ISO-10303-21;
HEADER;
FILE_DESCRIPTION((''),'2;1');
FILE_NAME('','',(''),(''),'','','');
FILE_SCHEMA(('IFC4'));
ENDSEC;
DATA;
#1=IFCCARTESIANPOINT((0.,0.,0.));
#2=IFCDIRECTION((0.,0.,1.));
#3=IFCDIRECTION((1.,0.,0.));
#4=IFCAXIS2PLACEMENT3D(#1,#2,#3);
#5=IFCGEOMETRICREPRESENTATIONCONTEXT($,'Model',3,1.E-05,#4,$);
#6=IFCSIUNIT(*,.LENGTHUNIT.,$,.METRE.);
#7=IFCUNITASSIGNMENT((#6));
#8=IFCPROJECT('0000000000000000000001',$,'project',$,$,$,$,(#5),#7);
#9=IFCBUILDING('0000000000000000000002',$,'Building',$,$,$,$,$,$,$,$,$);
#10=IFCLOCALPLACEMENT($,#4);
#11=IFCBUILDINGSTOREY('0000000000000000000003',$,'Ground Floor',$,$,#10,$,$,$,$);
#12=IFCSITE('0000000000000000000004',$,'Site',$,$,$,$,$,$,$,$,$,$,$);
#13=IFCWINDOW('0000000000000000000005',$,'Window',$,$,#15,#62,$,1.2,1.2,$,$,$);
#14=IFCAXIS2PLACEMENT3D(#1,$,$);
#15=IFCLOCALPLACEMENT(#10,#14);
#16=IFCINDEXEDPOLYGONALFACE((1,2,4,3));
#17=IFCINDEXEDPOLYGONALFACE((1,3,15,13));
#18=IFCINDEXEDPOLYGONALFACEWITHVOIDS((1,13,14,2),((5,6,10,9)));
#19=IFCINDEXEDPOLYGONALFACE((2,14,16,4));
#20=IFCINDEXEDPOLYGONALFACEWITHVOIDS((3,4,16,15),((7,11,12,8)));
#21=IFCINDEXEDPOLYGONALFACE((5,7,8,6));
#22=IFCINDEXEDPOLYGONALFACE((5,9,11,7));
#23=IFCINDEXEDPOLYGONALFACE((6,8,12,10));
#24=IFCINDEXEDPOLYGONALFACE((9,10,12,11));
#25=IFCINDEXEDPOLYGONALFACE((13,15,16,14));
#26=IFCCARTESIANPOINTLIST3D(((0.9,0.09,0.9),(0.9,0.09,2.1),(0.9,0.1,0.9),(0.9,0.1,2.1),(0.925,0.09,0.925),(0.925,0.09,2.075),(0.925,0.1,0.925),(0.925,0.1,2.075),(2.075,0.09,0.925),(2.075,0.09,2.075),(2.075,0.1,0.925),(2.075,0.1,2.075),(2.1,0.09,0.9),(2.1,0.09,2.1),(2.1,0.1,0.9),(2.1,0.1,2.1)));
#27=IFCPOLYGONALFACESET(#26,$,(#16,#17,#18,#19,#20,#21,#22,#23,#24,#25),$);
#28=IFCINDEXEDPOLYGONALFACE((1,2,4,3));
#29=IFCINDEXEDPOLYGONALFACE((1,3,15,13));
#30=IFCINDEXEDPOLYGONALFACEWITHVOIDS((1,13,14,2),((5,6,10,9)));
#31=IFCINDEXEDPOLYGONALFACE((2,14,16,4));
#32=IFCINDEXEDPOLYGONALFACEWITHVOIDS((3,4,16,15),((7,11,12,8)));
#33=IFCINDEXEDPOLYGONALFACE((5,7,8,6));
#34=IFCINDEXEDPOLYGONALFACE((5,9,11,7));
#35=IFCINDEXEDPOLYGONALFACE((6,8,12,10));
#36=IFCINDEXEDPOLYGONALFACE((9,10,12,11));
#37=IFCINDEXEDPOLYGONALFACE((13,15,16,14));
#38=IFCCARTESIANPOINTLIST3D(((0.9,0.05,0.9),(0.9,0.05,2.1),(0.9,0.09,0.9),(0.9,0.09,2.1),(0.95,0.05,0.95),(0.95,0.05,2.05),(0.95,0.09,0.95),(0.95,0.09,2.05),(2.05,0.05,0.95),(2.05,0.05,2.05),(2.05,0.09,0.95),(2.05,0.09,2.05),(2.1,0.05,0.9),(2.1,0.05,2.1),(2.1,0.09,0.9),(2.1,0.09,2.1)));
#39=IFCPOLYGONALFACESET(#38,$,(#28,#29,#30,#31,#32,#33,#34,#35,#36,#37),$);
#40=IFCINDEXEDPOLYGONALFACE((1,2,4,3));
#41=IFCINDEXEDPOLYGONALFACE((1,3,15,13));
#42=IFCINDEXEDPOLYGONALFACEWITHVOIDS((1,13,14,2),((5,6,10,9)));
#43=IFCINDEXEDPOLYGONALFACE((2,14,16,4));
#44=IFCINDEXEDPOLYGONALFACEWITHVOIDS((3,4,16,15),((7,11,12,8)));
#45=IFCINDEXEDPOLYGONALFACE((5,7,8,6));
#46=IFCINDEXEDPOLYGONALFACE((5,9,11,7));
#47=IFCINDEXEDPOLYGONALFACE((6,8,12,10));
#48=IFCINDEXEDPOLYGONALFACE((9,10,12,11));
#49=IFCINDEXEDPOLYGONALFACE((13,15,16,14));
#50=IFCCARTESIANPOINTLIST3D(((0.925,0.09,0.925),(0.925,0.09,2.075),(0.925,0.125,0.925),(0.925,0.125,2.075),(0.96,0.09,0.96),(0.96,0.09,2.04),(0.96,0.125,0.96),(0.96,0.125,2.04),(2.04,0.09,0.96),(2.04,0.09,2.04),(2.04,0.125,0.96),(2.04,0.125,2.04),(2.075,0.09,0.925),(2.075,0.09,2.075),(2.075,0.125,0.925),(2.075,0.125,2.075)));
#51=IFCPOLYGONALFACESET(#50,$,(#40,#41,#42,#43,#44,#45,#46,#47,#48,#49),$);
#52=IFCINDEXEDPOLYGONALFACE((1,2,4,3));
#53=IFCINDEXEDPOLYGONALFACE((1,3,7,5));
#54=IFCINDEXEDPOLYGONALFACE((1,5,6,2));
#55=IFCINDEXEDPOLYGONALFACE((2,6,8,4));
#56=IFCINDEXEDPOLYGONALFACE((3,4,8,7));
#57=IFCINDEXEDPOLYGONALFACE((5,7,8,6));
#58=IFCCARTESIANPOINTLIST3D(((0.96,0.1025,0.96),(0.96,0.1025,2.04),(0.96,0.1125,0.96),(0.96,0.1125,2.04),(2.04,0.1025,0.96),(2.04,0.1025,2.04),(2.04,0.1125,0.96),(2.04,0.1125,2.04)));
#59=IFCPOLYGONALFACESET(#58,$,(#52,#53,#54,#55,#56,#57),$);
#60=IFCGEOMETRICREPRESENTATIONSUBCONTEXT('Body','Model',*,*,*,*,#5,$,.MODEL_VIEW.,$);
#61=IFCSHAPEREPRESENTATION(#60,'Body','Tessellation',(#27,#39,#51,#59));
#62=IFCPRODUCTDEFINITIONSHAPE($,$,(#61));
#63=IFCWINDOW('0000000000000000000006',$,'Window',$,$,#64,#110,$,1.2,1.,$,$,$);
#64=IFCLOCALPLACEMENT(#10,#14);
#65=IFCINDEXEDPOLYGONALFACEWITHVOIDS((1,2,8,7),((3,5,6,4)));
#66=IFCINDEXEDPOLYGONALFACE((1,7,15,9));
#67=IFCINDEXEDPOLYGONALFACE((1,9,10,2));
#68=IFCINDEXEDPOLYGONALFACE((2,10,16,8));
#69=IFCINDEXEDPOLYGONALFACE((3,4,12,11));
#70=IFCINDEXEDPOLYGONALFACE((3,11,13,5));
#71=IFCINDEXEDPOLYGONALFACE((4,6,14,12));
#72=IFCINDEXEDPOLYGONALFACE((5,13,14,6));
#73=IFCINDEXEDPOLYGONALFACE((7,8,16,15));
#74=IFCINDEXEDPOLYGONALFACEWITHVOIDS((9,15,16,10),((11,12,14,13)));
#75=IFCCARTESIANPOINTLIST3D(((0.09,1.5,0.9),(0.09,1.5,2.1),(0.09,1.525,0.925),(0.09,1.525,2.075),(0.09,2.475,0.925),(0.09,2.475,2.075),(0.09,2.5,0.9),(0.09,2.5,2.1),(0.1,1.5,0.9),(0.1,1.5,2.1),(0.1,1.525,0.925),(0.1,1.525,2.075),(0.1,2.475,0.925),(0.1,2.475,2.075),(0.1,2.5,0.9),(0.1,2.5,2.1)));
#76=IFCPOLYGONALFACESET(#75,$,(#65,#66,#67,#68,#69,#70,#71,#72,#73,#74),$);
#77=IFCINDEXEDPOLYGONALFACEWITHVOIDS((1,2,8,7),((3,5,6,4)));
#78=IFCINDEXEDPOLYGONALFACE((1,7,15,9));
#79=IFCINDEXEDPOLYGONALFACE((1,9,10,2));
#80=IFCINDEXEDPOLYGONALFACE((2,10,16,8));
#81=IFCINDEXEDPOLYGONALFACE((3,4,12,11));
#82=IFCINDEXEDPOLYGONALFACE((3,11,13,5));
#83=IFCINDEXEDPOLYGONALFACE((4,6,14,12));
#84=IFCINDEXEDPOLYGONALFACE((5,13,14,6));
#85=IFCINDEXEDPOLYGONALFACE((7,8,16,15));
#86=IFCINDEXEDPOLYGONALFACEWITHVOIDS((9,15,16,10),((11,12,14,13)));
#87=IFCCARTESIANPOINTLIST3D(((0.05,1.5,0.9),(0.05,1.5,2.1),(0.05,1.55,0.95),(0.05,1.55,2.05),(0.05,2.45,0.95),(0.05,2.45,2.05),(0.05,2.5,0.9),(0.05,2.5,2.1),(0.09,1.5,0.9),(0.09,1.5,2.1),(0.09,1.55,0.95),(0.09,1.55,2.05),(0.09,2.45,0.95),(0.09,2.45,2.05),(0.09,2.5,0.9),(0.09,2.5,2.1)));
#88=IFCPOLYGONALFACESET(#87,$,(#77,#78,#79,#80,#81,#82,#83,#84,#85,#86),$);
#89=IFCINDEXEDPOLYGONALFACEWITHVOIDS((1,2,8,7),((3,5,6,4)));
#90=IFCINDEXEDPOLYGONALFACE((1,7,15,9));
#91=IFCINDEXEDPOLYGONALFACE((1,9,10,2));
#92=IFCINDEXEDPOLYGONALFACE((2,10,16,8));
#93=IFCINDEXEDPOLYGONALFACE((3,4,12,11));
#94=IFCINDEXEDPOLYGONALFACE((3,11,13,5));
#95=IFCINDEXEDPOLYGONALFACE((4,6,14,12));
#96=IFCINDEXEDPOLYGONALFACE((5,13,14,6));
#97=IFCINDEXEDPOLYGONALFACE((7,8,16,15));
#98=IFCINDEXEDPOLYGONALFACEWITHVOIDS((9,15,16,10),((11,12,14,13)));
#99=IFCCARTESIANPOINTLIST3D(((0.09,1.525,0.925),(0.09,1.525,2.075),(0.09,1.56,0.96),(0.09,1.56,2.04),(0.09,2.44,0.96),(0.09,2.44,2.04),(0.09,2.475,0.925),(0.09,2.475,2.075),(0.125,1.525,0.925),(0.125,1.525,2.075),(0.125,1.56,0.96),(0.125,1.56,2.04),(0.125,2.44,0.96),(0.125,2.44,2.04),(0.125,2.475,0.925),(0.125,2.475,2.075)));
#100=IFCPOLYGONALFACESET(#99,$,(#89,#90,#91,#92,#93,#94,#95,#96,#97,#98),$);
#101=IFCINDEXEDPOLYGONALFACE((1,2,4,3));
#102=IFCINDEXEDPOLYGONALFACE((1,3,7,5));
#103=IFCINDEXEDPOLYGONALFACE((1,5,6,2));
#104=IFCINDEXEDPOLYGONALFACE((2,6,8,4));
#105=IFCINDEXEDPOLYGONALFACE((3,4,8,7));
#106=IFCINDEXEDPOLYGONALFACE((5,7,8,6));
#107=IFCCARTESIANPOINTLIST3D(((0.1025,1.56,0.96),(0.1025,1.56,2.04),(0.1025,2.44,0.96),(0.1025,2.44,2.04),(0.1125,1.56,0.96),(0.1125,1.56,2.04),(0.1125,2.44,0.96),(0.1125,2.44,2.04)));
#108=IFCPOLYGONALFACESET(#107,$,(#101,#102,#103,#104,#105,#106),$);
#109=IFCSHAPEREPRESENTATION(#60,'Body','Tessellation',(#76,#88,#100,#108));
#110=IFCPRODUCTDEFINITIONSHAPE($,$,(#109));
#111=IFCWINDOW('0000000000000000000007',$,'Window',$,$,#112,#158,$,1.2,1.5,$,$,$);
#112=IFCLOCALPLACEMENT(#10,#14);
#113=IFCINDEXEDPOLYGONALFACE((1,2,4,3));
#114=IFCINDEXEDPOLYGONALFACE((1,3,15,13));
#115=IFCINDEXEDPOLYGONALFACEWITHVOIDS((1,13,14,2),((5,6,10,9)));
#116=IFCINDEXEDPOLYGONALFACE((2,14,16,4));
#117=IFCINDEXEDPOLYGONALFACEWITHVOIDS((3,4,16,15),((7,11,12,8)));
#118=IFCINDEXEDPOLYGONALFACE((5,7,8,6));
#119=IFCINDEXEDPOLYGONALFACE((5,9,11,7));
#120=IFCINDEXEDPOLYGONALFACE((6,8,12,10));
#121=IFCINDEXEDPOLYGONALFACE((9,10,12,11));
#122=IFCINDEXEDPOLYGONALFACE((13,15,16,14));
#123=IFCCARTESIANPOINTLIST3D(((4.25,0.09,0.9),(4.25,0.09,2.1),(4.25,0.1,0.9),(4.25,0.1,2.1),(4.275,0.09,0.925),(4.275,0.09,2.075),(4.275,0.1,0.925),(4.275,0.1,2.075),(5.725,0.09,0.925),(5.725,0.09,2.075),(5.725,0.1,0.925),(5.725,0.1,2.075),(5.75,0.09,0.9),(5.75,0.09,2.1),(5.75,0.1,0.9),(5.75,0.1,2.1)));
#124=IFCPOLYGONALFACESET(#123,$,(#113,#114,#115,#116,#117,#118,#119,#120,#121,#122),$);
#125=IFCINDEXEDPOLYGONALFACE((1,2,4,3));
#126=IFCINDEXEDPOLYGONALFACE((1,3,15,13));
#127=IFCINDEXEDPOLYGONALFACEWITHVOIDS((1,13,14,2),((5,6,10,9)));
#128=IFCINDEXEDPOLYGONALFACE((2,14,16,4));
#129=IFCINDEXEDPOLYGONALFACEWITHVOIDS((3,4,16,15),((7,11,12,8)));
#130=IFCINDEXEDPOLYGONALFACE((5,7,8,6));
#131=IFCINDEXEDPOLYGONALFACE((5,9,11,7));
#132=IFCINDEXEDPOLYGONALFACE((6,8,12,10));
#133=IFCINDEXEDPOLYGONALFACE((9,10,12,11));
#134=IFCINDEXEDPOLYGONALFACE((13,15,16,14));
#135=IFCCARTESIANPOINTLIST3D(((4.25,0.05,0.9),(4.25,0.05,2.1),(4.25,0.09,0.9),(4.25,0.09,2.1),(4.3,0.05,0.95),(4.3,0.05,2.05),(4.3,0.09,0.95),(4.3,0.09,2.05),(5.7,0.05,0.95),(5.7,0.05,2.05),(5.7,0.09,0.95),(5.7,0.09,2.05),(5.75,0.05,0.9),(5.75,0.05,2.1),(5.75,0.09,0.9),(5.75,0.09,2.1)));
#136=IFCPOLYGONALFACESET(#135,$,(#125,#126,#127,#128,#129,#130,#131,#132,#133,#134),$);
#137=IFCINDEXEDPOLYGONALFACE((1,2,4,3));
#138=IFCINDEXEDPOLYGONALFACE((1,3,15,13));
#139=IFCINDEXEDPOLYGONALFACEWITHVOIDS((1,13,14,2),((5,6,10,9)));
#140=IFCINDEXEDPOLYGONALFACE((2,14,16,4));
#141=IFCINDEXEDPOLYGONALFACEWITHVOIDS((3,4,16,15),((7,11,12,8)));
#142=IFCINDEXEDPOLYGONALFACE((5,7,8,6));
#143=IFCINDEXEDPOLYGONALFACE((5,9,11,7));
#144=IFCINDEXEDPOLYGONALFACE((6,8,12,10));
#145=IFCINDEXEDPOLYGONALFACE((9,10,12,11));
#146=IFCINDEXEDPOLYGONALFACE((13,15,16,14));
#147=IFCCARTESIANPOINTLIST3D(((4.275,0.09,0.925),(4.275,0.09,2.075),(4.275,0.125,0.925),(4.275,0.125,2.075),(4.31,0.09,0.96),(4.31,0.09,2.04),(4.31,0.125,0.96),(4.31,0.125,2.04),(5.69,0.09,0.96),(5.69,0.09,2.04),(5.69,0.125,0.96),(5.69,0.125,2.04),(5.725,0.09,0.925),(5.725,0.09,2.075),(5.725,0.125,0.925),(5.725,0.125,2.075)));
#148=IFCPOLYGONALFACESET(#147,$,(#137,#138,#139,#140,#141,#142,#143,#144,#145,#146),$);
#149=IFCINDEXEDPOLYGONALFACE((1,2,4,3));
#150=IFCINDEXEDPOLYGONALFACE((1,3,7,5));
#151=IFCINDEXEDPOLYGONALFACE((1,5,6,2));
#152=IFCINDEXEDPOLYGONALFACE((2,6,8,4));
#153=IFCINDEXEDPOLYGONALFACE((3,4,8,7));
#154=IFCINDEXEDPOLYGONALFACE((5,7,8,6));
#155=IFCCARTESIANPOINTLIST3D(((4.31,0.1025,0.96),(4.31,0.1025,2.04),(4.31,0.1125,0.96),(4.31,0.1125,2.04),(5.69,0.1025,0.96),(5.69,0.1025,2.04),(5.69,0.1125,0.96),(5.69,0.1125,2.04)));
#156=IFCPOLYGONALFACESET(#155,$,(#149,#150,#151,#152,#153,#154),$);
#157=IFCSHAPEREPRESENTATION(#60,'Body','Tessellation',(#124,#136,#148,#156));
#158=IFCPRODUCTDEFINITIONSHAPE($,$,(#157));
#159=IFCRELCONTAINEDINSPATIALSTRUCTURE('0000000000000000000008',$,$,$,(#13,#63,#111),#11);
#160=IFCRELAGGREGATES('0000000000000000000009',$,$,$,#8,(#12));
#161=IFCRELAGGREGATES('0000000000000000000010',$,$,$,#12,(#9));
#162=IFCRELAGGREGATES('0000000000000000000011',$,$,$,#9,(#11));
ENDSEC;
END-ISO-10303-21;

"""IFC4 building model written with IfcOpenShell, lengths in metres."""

from ifc_helpers import new_model, si_unit, frame, origin_with_axes, place, context, subcontext, project, spatial, line, indexed_curve, outline, extrude, element, save


model = new_model("IFC4")

# Units and contexts
model_context = context("Model", 3, precision=1e-05, world=origin_with_axes())
body_context = subcontext(model_context, "Body", "Model", "MODEL_VIEW")
ifc_project = project(units=[si_unit("LENGTHUNIT", "METRE")], contexts=[model_context])

# Site, building, storey
site = spatial("IfcSite", under=ifc_project, Name="Site")
building = spatial("IfcBuilding", under=site, Name="Building")
storey_placement = place(None, origin_with_axes())
storey = spatial("IfcBuildingStorey", under=building, at=storey_placement, Name="Ground Floor")

# Windows
window_1_placement = place(storey_placement, frame((0.9, 0.0, 0.9), z_axis=(0.0, 0.0, 1.0), x_axis=(1.0, 0.0, 0.0)))
element("IfcWindow", 1, at=window_1_placement, inside=storey, Name="Window", OverallHeight=1.2, OverallWidth=1.2, context=body_context, shape_type="SweptSolid", body=[
    extrude(outline(indexed_curve([(0.0, 0.0), (1.2, 0.0), (1.2, 1.2), (0.0, 1.2)], segments=[line(1, 2, 3, 4, 1)]), holes=[indexed_curve([(0.025, 0.025), (1.175, 0.025), (1.175, 1.175), (0.025, 1.175)], segments=[line(1, 2, 3, 4, 1)])]), frame((0.0, 0.09, 0.0), z_axis=(0.0, -1.0, 0.0), x_axis=(1.0, 0.0, 0.0)), (0.0, 0.0, -1.0), 0.01),
    extrude(outline(indexed_curve([(0.0, 0.0), (1.2, 0.0), (1.2, 1.2), (0.0, 1.2)], segments=[line(1, 2, 3, 4, 1)]), holes=[indexed_curve([(0.05, 0.05), (1.15, 0.05), (1.15, 1.15), (0.05, 1.15)], segments=[line(1, 2, 3, 4, 1)])]), frame((0.0, 0.05, 0.0), z_axis=(0.0, -1.0, 0.0), x_axis=(1.0, 0.0, 0.0)), (0.0, 0.0, -1.0), 0.04),
    extrude(outline(indexed_curve([(0.0, 0.0), (1.15, 0.0), (1.15, 1.15), (0.0, 1.15)], segments=[line(1, 2, 3, 4, 1)]), holes=[indexed_curve([(0.035, 0.035), (1.115, 0.035), (1.115, 1.115), (0.035, 1.115)], segments=[line(1, 2, 3, 4, 1)])]), frame((0.025, 0.09, 0.025), z_axis=(0.0, -1.0, 0.0), x_axis=(1.0, 0.0, 0.0)), (0.0, 0.0, -1.0), 0.035),
    extrude(outline(indexed_curve([(0.035, 0.035), (1.115, 0.035), (1.115, 1.115), (0.035, 1.115)], segments=[line(1, 2, 3, 4, 1)])), frame((0.025, 0.1025, 0.025), z_axis=(0.0, -1.0, 0.0), x_axis=(1.0, 0.0, 0.0)), (0.0, 0.0, -1.0), 0.01),
])
window_2_placement = place(storey_placement, frame((0.0, 2.5, 0.9), z_axis=(0.0, 0.0, 1.0), x_axis=(0.0, -1.0, 0.0)))
element("IfcWindow", 2, at=window_2_placement, inside=storey, Name="Window", OverallHeight=1.2, OverallWidth=1.0, context=body_context, shape_type="SweptSolid", body=[
    extrude(outline(indexed_curve([(0.0, 0.0), (1.0, 0.0), (1.0, 1.2), (0.0, 1.2)], segments=[line(1, 2, 3, 4, 1)]), holes=[indexed_curve([(0.025, 0.025), (0.975, 0.025), (0.975, 1.175), (0.025, 1.175)], segments=[line(1, 2, 3, 4, 1)])]), frame((0.0, 0.09, 0.0), z_axis=(0.0, -1.0, 0.0), x_axis=(1.0, 0.0, 0.0)), (0.0, 0.0, -1.0), 0.01),
    extrude(outline(indexed_curve([(0.0, 0.0), (1.0, 0.0), (1.0, 1.2), (0.0, 1.2)], segments=[line(1, 2, 3, 4, 1)]), holes=[indexed_curve([(0.05, 0.05), (0.95, 0.05), (0.95, 1.15), (0.05, 1.15)], segments=[line(1, 2, 3, 4, 1)])]), frame((0.0, 0.05, 0.0), z_axis=(0.0, -1.0, 0.0), x_axis=(1.0, 0.0, 0.0)), (0.0, 0.0, -1.0), 0.04),
    extrude(outline(indexed_curve([(0.0, 0.0), (0.95, 0.0), (0.95, 1.15), (0.0, 1.15)], segments=[line(1, 2, 3, 4, 1)]), holes=[indexed_curve([(0.035, 0.035), (0.915, 0.035), (0.915, 1.115), (0.035, 1.115)], segments=[line(1, 2, 3, 4, 1)])]), frame((0.025, 0.09, 0.025), z_axis=(0.0, -1.0, 0.0), x_axis=(1.0, 0.0, 0.0)), (0.0, 0.0, -1.0), 0.035),
    extrude(outline(indexed_curve([(0.035, 0.035), (0.915, 0.035), (0.915, 1.115), (0.035, 1.115)], segments=[line(1, 2, 3, 4, 1)])), frame((0.025, 0.1025, 0.025), z_axis=(0.0, -1.0, 0.0), x_axis=(1.0, 0.0, 0.0)), (0.0, 0.0, -1.0), 0.01),
])
window_3_placement = place(storey_placement, frame((4.25, 0.0, 0.9), z_axis=(0.0, 0.0, 1.0), x_axis=(1.0, 0.0, 0.0)))
element("IfcWindow", 3, at=window_3_placement, inside=storey, Name="Window", OverallHeight=1.2, OverallWidth=1.5, context=body_context, shape_type="SweptSolid", body=[
    extrude(outline(indexed_curve([(0.0, 0.0), (1.5, 0.0), (1.5, 1.2), (0.0, 1.2)], segments=[line(1, 2, 3, 4, 1)]), holes=[indexed_curve([(0.025, 0.025), (1.475, 0.025), (1.475, 1.175), (0.025, 1.175)], segments=[line(1, 2, 3, 4, 1)])]), frame((0.0, 0.09, 0.0), z_axis=(0.0, -1.0, 0.0), x_axis=(1.0, 0.0, 0.0)), (0.0, 0.0, -1.0), 0.01),
    extrude(outline(indexed_curve([(0.0, 0.0), (1.5, 0.0), (1.5, 1.2), (0.0, 1.2)], segments=[line(1, 2, 3, 4, 1)]), holes=[indexed_curve([(0.05, 0.05), (1.45, 0.05), (1.45, 1.15), (0.05, 1.15)], segments=[line(1, 2, 3, 4, 1)])]), frame((0.0, 0.05, 0.0), z_axis=(0.0, -1.0, 0.0), x_axis=(1.0, 0.0, 0.0)), (0.0, 0.0, -1.0), 0.04),
    extrude(outline(indexed_curve([(0.0, 0.0), (1.45, 0.0), (1.45, 1.15), (0.0, 1.15)], segments=[line(1, 2, 3, 4, 1)]), holes=[indexed_curve([(0.035, 0.035), (1.415, 0.035), (1.415, 1.115), (0.035, 1.115)], segments=[line(1, 2, 3, 4, 1)])]), frame((0.025, 0.09, 0.025), z_axis=(0.0, -1.0, 0.0), x_axis=(1.0, 0.0, 0.0)), (0.0, 0.0, -1.0), 0.035),
    extrude(outline(indexed_curve([(0.035, 0.035), (1.415, 0.035), (1.415, 1.115), (0.035, 1.115)], segments=[line(1, 2, 3, 4, 1)])), frame((0.025, 0.1025, 0.025), z_axis=(0.0, -1.0, 0.0), x_axis=(1.0, 0.0, 0.0)), (0.0, 0.0, -1.0), 0.01),
])

save(model, "model.ifc")
